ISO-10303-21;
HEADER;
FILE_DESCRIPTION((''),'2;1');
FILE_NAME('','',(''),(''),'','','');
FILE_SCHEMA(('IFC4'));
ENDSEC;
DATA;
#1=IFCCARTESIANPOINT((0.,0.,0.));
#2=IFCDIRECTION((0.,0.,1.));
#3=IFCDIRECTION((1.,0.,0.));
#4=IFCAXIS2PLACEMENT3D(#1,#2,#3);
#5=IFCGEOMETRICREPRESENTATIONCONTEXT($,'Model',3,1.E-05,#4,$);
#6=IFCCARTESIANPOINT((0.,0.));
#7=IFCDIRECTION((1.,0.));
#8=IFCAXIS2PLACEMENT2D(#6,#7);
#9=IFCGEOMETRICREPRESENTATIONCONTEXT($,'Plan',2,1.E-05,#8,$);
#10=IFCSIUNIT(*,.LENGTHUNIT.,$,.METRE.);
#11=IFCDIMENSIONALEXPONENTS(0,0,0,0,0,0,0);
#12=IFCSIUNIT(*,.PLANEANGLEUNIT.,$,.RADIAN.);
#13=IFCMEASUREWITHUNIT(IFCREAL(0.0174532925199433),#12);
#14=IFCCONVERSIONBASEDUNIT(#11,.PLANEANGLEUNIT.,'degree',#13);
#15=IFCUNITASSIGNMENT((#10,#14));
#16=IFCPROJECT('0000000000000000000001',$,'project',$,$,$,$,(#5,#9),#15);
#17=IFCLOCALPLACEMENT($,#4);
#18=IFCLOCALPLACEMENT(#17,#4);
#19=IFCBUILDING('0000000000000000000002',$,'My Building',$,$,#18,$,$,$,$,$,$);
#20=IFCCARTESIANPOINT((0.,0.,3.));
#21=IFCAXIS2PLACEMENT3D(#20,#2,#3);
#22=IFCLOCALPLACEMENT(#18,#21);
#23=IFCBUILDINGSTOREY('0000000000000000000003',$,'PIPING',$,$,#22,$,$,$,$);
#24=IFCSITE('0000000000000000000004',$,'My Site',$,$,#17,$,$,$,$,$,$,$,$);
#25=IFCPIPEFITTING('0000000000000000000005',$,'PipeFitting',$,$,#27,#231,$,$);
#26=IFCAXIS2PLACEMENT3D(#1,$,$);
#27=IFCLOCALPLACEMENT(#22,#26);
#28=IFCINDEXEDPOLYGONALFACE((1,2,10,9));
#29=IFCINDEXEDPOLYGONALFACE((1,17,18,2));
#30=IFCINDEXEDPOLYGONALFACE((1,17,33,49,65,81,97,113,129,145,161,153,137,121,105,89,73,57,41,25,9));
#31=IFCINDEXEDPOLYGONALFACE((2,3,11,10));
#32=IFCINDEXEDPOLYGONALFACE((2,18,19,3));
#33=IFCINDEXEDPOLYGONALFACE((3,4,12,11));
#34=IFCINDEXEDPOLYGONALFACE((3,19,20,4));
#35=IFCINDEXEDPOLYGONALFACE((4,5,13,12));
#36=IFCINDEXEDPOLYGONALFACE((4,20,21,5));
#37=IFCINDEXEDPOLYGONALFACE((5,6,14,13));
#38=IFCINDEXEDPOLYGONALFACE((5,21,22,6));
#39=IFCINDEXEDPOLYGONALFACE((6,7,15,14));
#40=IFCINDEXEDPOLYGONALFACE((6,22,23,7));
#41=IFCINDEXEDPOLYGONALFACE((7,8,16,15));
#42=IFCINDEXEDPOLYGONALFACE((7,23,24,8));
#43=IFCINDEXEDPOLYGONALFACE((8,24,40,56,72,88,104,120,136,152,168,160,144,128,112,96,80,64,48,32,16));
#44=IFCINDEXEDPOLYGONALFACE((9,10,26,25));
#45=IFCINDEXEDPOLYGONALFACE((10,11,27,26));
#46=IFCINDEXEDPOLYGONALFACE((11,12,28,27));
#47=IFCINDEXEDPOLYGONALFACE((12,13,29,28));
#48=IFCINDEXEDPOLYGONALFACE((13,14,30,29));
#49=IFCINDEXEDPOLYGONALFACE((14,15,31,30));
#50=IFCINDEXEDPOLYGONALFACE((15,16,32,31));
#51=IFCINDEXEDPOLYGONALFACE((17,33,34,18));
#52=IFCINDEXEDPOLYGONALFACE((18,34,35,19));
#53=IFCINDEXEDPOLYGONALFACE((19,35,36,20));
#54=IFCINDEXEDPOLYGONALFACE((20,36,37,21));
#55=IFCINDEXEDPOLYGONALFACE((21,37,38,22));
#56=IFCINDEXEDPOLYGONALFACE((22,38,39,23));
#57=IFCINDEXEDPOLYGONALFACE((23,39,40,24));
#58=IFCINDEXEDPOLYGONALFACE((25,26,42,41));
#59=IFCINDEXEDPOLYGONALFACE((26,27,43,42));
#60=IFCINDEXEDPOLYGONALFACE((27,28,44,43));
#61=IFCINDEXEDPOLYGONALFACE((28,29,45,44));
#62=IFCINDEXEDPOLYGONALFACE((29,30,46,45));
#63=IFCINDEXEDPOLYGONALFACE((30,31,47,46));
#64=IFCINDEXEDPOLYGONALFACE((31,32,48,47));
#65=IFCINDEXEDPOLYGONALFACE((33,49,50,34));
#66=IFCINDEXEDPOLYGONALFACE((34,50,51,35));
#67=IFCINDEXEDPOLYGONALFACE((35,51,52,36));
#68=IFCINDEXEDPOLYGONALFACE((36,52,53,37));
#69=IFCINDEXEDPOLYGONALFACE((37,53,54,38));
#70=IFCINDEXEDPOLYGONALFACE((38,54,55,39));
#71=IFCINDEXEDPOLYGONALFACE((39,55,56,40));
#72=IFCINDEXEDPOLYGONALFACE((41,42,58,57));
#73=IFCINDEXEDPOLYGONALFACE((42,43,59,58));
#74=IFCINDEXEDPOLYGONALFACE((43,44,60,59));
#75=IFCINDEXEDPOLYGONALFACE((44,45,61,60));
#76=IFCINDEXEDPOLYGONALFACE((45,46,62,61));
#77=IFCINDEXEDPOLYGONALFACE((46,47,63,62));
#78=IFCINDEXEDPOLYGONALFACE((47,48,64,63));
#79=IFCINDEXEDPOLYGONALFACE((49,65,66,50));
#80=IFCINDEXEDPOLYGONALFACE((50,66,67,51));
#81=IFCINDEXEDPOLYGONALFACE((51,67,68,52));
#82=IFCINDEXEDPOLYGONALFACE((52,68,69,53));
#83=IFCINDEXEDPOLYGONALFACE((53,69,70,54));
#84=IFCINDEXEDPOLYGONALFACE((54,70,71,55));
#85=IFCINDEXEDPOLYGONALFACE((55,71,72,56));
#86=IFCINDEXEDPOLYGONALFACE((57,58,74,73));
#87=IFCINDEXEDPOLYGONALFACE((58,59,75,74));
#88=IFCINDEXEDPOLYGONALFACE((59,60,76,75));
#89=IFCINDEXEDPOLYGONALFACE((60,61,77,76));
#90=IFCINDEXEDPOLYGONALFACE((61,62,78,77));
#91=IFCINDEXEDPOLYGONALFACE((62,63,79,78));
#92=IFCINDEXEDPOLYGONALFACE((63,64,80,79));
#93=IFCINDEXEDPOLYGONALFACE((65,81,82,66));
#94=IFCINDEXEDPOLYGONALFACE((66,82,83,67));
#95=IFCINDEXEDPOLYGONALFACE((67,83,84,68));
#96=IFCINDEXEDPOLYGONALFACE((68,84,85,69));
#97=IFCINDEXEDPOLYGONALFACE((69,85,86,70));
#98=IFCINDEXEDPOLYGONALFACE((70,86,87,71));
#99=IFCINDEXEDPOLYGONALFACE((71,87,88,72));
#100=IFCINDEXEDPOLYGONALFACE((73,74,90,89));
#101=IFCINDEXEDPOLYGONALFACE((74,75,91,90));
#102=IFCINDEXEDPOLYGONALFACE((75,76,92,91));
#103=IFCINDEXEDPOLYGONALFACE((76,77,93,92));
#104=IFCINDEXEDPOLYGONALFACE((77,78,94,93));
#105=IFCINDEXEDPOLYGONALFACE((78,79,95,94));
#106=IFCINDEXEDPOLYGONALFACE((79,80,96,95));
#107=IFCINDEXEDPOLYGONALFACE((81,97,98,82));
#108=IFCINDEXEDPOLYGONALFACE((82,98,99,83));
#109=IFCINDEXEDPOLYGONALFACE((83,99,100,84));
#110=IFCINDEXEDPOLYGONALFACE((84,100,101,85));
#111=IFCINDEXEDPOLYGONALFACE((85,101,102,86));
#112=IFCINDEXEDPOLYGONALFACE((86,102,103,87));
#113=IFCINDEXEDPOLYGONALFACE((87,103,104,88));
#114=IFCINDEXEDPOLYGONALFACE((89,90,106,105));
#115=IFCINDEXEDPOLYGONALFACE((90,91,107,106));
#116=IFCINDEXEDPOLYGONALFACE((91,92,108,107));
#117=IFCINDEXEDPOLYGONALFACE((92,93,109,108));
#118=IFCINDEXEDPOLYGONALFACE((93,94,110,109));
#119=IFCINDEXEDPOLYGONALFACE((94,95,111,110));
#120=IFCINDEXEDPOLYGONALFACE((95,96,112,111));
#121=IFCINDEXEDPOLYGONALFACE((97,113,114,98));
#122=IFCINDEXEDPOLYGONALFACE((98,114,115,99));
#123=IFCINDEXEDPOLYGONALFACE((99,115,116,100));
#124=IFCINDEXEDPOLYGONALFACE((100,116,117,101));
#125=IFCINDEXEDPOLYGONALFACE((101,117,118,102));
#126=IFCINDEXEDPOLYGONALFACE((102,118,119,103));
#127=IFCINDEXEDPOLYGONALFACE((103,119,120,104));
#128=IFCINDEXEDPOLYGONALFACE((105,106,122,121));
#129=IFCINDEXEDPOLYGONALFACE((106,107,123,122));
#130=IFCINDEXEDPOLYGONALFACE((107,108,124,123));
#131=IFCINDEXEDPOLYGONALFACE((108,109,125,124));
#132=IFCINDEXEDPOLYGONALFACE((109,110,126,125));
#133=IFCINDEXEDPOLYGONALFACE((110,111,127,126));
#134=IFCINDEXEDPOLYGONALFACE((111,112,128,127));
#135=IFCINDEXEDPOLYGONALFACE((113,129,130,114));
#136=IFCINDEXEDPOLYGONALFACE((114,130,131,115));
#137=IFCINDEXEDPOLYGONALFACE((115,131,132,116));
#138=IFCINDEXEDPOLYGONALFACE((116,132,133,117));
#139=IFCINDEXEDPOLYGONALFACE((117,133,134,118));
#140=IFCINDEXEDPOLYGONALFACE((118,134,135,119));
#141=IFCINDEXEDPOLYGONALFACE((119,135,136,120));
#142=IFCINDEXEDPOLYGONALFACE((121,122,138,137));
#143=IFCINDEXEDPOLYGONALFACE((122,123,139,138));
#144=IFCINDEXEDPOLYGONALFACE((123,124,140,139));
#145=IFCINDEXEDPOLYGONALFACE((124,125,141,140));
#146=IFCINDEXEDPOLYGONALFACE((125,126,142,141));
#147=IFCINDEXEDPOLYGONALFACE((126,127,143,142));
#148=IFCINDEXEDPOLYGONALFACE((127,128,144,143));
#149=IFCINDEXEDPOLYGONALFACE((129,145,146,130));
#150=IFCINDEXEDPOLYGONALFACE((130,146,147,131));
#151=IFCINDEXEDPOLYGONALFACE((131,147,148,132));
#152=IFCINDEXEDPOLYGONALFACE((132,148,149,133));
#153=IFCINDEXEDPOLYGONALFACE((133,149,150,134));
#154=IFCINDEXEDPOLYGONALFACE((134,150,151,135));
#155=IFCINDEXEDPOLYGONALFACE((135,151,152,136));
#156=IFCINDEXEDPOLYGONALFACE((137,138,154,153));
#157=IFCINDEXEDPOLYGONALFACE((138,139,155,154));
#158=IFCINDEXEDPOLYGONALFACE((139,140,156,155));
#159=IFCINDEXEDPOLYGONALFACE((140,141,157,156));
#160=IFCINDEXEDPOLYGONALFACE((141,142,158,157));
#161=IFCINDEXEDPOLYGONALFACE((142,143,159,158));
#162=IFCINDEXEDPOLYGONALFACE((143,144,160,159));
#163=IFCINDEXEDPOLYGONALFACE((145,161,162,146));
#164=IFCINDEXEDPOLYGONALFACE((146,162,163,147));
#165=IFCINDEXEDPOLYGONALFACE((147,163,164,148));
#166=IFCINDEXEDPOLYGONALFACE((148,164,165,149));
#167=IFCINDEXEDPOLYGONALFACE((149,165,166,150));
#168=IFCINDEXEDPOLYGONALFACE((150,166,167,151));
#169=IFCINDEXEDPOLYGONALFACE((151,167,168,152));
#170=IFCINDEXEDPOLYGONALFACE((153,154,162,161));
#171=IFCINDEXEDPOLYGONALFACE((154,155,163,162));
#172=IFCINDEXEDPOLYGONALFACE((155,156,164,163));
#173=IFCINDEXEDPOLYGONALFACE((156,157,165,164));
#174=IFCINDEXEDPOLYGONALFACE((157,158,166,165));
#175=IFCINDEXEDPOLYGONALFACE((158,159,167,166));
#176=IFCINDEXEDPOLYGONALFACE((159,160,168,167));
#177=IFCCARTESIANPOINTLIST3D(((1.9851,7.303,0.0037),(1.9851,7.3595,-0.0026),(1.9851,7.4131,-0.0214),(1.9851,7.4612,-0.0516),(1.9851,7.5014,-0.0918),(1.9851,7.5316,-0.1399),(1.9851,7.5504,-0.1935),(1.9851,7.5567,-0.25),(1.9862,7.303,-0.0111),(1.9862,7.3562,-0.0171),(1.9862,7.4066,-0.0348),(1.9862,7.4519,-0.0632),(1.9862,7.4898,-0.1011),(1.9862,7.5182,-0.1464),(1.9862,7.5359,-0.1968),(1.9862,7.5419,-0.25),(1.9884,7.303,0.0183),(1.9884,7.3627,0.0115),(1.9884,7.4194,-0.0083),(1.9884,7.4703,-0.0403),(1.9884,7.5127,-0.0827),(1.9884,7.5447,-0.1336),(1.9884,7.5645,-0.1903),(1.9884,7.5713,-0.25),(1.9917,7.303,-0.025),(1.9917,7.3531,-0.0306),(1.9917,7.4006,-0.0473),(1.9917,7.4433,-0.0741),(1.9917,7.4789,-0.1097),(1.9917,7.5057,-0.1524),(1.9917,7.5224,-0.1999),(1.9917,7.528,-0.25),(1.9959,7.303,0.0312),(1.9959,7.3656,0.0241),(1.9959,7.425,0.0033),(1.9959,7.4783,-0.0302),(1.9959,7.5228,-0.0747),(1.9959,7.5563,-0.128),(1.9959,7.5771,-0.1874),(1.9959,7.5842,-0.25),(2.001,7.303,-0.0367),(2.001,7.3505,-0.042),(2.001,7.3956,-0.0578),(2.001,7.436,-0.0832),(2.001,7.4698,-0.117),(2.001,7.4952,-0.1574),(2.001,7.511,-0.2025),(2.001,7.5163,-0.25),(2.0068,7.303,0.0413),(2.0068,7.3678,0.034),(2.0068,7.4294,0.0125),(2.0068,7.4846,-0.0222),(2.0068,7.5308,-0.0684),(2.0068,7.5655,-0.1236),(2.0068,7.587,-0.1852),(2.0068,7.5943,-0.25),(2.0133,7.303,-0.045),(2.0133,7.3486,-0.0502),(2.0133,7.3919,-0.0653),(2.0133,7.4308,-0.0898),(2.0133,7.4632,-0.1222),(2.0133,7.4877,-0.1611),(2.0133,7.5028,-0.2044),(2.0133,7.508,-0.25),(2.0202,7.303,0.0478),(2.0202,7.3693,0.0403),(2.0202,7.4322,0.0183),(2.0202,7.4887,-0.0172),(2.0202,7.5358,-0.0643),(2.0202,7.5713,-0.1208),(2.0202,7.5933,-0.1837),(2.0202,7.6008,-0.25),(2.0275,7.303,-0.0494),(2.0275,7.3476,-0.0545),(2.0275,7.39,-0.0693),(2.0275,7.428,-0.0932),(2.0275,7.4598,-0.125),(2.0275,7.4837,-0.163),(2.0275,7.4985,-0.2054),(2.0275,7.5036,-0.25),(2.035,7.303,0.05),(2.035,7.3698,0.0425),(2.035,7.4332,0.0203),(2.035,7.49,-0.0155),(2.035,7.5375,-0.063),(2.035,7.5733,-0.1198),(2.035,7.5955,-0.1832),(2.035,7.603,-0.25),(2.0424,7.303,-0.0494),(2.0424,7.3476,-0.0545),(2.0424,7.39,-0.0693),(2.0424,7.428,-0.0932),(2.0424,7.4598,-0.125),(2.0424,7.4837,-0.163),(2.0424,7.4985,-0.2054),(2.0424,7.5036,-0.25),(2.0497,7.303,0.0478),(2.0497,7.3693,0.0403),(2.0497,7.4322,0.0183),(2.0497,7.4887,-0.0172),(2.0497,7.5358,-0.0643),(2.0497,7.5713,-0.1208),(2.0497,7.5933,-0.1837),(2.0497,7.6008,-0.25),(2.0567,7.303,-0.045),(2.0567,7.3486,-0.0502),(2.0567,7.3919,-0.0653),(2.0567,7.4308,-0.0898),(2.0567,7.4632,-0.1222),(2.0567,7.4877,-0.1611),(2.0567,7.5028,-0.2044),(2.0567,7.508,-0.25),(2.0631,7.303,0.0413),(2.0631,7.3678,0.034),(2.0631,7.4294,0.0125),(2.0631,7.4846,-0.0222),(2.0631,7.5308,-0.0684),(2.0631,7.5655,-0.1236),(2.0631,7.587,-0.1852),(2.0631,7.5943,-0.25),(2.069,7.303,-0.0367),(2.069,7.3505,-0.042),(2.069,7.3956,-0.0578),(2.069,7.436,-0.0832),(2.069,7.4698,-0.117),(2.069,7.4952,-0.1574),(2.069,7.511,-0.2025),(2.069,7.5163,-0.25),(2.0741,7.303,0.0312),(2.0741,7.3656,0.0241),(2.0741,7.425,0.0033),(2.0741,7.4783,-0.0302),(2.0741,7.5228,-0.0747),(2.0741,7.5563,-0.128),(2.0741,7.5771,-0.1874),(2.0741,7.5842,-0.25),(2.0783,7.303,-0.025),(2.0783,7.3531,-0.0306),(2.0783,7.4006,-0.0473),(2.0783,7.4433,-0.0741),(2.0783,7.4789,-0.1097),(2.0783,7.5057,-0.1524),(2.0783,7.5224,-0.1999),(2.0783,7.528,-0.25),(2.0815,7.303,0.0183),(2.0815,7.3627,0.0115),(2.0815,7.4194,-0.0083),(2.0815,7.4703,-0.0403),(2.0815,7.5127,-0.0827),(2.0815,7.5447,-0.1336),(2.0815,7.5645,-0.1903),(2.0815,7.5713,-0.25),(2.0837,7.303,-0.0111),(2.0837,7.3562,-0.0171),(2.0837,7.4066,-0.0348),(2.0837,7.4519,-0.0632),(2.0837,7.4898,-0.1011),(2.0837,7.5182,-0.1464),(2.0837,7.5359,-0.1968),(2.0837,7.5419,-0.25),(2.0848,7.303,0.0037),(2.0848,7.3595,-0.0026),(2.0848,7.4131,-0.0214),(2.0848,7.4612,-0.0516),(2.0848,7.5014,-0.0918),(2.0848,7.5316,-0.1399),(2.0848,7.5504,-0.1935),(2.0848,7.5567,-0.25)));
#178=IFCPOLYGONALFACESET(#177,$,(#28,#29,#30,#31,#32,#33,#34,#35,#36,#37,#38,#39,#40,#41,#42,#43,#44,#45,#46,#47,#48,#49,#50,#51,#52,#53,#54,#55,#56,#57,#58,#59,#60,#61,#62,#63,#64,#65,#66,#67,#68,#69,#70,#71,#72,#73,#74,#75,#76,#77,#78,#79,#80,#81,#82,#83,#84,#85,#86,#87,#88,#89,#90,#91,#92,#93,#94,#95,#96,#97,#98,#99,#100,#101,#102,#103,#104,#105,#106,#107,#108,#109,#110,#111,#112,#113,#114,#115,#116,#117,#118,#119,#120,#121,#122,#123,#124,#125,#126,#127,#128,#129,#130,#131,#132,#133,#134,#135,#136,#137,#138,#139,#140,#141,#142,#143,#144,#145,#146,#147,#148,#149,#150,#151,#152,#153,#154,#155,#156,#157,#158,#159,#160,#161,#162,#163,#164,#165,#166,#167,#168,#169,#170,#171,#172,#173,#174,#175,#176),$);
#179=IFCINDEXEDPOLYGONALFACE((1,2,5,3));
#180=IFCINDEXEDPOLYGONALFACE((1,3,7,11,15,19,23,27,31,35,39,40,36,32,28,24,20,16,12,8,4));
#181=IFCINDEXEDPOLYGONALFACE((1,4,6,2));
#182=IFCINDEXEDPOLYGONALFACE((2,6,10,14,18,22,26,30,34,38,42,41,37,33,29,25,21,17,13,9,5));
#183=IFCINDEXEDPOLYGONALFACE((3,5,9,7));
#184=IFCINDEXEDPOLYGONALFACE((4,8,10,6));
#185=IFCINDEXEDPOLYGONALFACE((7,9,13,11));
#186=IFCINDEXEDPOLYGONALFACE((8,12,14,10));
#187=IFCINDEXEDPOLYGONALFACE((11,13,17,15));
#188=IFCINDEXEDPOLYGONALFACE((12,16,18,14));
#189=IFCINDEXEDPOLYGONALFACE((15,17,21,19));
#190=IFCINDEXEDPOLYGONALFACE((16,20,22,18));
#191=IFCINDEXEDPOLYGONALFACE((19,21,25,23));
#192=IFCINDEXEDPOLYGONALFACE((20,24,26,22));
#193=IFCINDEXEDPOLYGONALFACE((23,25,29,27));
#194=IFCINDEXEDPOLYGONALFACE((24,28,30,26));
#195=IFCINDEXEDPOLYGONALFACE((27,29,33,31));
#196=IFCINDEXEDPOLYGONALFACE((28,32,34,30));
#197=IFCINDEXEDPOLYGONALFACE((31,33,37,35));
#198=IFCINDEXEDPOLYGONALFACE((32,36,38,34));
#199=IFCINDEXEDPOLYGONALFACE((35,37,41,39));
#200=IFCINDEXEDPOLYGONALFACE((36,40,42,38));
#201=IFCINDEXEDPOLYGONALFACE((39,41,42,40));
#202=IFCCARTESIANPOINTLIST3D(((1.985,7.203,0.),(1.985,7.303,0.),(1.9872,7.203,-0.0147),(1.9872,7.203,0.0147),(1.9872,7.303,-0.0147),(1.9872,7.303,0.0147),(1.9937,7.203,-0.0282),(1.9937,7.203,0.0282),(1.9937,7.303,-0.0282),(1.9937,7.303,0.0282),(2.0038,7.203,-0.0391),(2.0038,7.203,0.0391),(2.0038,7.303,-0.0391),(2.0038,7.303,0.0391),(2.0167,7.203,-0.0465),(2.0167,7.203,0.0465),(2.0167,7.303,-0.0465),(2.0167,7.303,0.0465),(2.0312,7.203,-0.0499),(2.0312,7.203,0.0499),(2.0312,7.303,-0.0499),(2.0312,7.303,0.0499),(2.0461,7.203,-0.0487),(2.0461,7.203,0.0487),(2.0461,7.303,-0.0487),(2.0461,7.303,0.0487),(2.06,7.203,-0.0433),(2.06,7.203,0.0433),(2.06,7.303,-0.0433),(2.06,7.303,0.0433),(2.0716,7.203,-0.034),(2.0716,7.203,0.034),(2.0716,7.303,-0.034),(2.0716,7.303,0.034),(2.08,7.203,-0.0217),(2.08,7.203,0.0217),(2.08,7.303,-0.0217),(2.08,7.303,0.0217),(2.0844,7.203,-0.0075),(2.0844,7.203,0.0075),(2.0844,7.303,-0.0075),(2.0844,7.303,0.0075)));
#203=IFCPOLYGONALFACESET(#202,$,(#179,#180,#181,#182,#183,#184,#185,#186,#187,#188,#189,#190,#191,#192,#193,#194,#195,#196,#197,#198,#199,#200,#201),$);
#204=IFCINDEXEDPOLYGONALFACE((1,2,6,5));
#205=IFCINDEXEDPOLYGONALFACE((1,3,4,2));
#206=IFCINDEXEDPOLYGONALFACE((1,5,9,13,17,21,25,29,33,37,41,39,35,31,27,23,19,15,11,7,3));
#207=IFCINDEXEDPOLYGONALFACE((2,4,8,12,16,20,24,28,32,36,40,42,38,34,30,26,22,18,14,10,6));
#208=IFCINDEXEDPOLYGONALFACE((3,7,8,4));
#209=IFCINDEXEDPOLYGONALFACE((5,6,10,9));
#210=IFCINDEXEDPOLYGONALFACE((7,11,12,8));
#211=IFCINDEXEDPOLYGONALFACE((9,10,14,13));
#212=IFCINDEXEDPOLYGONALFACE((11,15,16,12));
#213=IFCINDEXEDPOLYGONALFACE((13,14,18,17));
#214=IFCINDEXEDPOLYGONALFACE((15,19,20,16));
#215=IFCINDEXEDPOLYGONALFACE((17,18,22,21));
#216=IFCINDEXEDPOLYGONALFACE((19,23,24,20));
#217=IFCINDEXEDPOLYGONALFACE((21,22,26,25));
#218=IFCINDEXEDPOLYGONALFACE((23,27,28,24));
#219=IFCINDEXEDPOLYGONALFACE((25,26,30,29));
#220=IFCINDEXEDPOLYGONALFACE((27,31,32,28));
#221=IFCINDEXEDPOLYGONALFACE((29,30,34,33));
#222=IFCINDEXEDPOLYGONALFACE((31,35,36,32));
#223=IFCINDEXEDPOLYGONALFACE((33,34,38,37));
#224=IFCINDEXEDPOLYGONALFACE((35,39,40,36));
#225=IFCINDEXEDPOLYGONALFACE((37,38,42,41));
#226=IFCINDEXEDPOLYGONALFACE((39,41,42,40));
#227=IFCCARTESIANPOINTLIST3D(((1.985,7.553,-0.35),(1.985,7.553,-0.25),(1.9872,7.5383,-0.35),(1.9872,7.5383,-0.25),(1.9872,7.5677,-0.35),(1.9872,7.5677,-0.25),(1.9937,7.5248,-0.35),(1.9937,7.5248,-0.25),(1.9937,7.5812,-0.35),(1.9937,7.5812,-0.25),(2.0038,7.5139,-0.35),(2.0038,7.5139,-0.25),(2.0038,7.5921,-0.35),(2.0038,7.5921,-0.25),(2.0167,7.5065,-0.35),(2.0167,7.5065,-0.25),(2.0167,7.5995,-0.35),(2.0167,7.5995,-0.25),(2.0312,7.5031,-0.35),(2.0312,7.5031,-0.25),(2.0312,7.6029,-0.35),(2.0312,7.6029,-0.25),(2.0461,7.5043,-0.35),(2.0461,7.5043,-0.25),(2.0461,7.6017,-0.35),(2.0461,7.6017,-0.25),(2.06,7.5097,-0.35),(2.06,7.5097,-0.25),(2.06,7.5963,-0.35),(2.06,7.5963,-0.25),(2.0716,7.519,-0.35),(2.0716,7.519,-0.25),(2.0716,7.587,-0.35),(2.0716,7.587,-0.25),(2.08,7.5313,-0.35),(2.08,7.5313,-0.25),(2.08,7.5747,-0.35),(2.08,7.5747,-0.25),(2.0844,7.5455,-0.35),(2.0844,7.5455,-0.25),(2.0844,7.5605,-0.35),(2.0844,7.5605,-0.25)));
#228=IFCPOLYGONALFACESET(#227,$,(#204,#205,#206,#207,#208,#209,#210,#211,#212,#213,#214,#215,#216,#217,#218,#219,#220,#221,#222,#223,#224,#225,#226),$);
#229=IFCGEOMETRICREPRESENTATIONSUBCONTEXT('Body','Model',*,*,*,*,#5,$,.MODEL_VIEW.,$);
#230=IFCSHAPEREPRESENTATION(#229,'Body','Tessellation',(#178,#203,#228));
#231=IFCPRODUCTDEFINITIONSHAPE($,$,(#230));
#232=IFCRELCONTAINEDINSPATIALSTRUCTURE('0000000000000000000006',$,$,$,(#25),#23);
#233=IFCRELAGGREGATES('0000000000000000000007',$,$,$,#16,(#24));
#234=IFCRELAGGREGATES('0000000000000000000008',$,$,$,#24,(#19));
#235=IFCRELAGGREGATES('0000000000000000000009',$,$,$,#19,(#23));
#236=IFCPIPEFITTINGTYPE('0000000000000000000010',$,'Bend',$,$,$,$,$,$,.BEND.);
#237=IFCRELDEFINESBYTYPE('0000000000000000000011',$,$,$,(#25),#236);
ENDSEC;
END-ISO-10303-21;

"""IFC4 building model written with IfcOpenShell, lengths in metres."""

from ifc_helpers import new_model, entity, si_unit, converted_unit, frame, origin_with_axes, origin_2d_with_axis, place, context, subcontext, project, spatial, circle, extrude, source, transform, mapped, type_object, type_shapes, element, save


model = new_model("IFC4")

# Units and contexts
model_context = context("Model", 3, precision=1e-05, world=origin_with_axes())
plan_context = context("Plan", 2, precision=1e-05, world=origin_2d_with_axis())
body_context = subcontext(model_context, "Body", "Model", "MODEL_VIEW")
ifc_project = project(units=[si_unit("LENGTHUNIT", "METRE"), converted_unit("PLANEANGLEUNIT", "degree", entity("IfcReal", 0.0174532925199433), si_unit("PLANEANGLEUNIT", "RADIAN"), dimensions=[0, 0, 0, 0, 0, 0, 0])], contexts=[model_context, plan_context])

# Site, building, storey
site_placement = place(None, origin_with_axes())
site = spatial("IfcSite", under=ifc_project, at=site_placement, Name="My Site")
building_placement = place(site_placement, origin_with_axes())
building = spatial("IfcBuilding", under=site, at=building_placement, Name="My Building")
storey_placement = place(building_placement, frame((0.0, 0.0, 3.0), z_axis=(0.0, 0.0, 1.0), x_axis=(1.0, 0.0, 0.0)))
storey = spatial("IfcBuildingStorey", under=building, at=storey_placement, Name="PIPING")

# Shared definitions
pipe_fitting_type = type_object("IfcPipeFittingType", Name="Bend", PredefinedType="BEND")
shared_shape = source(origin_with_axes(), body_context, "Body", "SolidModel", [
    entity("IfcSweptDiskSolid", entity("IfcIndexedPolyCurve", entity("IfcCartesianPointList3D", [[0.0, 0.0, -0.1], [0.0, 0.0732, -0.2768], [0.0, 0.25, -0.35]]), [entity("IfcArcIndex", [1, 2, 3])]), 0.05),
    extrude(circle(Radius=0.05), origin_with_axes(), (0.0, 0.0, -1.0), 0.1),
    extrude(circle(Radius=0.05), frame((0.0, 0.25, -0.35), z_axis=(0.0, 1.0, 0.0), x_axis=(1.0, 0.0, 0.0)), (0.0, 0.0, 1.0), 0.1),
])
type_shapes(pipe_fitting_type, [shared_shape])

# Pipe fitting
for number, where, z_axis, x_axis, name in (
    (1, (2.035, 7.203, 0.0), (0.0, -1.0, 0.0), (-1.0, 0.0, 0.0), "PipeFitting"),
):
    element("IfcPipeFitting", number, at=place(storey_placement, frame(where, z_axis=z_axis, x_axis=x_axis)), inside=storey, type_object=pipe_fitting_type, Name=name, context=body_context, shape_type="MappedRepresentation", body=[
        mapped(shared_shape, transform((0.0, 0.0, 0.0), x_axis=(1.0, 0.0, 0.0), y_axis=(0.0, 1.0, 0.0), z_axis=(0.0, 0.0, 1.0), scale=1.0)),
    ])

save(model, "model.ifc")
